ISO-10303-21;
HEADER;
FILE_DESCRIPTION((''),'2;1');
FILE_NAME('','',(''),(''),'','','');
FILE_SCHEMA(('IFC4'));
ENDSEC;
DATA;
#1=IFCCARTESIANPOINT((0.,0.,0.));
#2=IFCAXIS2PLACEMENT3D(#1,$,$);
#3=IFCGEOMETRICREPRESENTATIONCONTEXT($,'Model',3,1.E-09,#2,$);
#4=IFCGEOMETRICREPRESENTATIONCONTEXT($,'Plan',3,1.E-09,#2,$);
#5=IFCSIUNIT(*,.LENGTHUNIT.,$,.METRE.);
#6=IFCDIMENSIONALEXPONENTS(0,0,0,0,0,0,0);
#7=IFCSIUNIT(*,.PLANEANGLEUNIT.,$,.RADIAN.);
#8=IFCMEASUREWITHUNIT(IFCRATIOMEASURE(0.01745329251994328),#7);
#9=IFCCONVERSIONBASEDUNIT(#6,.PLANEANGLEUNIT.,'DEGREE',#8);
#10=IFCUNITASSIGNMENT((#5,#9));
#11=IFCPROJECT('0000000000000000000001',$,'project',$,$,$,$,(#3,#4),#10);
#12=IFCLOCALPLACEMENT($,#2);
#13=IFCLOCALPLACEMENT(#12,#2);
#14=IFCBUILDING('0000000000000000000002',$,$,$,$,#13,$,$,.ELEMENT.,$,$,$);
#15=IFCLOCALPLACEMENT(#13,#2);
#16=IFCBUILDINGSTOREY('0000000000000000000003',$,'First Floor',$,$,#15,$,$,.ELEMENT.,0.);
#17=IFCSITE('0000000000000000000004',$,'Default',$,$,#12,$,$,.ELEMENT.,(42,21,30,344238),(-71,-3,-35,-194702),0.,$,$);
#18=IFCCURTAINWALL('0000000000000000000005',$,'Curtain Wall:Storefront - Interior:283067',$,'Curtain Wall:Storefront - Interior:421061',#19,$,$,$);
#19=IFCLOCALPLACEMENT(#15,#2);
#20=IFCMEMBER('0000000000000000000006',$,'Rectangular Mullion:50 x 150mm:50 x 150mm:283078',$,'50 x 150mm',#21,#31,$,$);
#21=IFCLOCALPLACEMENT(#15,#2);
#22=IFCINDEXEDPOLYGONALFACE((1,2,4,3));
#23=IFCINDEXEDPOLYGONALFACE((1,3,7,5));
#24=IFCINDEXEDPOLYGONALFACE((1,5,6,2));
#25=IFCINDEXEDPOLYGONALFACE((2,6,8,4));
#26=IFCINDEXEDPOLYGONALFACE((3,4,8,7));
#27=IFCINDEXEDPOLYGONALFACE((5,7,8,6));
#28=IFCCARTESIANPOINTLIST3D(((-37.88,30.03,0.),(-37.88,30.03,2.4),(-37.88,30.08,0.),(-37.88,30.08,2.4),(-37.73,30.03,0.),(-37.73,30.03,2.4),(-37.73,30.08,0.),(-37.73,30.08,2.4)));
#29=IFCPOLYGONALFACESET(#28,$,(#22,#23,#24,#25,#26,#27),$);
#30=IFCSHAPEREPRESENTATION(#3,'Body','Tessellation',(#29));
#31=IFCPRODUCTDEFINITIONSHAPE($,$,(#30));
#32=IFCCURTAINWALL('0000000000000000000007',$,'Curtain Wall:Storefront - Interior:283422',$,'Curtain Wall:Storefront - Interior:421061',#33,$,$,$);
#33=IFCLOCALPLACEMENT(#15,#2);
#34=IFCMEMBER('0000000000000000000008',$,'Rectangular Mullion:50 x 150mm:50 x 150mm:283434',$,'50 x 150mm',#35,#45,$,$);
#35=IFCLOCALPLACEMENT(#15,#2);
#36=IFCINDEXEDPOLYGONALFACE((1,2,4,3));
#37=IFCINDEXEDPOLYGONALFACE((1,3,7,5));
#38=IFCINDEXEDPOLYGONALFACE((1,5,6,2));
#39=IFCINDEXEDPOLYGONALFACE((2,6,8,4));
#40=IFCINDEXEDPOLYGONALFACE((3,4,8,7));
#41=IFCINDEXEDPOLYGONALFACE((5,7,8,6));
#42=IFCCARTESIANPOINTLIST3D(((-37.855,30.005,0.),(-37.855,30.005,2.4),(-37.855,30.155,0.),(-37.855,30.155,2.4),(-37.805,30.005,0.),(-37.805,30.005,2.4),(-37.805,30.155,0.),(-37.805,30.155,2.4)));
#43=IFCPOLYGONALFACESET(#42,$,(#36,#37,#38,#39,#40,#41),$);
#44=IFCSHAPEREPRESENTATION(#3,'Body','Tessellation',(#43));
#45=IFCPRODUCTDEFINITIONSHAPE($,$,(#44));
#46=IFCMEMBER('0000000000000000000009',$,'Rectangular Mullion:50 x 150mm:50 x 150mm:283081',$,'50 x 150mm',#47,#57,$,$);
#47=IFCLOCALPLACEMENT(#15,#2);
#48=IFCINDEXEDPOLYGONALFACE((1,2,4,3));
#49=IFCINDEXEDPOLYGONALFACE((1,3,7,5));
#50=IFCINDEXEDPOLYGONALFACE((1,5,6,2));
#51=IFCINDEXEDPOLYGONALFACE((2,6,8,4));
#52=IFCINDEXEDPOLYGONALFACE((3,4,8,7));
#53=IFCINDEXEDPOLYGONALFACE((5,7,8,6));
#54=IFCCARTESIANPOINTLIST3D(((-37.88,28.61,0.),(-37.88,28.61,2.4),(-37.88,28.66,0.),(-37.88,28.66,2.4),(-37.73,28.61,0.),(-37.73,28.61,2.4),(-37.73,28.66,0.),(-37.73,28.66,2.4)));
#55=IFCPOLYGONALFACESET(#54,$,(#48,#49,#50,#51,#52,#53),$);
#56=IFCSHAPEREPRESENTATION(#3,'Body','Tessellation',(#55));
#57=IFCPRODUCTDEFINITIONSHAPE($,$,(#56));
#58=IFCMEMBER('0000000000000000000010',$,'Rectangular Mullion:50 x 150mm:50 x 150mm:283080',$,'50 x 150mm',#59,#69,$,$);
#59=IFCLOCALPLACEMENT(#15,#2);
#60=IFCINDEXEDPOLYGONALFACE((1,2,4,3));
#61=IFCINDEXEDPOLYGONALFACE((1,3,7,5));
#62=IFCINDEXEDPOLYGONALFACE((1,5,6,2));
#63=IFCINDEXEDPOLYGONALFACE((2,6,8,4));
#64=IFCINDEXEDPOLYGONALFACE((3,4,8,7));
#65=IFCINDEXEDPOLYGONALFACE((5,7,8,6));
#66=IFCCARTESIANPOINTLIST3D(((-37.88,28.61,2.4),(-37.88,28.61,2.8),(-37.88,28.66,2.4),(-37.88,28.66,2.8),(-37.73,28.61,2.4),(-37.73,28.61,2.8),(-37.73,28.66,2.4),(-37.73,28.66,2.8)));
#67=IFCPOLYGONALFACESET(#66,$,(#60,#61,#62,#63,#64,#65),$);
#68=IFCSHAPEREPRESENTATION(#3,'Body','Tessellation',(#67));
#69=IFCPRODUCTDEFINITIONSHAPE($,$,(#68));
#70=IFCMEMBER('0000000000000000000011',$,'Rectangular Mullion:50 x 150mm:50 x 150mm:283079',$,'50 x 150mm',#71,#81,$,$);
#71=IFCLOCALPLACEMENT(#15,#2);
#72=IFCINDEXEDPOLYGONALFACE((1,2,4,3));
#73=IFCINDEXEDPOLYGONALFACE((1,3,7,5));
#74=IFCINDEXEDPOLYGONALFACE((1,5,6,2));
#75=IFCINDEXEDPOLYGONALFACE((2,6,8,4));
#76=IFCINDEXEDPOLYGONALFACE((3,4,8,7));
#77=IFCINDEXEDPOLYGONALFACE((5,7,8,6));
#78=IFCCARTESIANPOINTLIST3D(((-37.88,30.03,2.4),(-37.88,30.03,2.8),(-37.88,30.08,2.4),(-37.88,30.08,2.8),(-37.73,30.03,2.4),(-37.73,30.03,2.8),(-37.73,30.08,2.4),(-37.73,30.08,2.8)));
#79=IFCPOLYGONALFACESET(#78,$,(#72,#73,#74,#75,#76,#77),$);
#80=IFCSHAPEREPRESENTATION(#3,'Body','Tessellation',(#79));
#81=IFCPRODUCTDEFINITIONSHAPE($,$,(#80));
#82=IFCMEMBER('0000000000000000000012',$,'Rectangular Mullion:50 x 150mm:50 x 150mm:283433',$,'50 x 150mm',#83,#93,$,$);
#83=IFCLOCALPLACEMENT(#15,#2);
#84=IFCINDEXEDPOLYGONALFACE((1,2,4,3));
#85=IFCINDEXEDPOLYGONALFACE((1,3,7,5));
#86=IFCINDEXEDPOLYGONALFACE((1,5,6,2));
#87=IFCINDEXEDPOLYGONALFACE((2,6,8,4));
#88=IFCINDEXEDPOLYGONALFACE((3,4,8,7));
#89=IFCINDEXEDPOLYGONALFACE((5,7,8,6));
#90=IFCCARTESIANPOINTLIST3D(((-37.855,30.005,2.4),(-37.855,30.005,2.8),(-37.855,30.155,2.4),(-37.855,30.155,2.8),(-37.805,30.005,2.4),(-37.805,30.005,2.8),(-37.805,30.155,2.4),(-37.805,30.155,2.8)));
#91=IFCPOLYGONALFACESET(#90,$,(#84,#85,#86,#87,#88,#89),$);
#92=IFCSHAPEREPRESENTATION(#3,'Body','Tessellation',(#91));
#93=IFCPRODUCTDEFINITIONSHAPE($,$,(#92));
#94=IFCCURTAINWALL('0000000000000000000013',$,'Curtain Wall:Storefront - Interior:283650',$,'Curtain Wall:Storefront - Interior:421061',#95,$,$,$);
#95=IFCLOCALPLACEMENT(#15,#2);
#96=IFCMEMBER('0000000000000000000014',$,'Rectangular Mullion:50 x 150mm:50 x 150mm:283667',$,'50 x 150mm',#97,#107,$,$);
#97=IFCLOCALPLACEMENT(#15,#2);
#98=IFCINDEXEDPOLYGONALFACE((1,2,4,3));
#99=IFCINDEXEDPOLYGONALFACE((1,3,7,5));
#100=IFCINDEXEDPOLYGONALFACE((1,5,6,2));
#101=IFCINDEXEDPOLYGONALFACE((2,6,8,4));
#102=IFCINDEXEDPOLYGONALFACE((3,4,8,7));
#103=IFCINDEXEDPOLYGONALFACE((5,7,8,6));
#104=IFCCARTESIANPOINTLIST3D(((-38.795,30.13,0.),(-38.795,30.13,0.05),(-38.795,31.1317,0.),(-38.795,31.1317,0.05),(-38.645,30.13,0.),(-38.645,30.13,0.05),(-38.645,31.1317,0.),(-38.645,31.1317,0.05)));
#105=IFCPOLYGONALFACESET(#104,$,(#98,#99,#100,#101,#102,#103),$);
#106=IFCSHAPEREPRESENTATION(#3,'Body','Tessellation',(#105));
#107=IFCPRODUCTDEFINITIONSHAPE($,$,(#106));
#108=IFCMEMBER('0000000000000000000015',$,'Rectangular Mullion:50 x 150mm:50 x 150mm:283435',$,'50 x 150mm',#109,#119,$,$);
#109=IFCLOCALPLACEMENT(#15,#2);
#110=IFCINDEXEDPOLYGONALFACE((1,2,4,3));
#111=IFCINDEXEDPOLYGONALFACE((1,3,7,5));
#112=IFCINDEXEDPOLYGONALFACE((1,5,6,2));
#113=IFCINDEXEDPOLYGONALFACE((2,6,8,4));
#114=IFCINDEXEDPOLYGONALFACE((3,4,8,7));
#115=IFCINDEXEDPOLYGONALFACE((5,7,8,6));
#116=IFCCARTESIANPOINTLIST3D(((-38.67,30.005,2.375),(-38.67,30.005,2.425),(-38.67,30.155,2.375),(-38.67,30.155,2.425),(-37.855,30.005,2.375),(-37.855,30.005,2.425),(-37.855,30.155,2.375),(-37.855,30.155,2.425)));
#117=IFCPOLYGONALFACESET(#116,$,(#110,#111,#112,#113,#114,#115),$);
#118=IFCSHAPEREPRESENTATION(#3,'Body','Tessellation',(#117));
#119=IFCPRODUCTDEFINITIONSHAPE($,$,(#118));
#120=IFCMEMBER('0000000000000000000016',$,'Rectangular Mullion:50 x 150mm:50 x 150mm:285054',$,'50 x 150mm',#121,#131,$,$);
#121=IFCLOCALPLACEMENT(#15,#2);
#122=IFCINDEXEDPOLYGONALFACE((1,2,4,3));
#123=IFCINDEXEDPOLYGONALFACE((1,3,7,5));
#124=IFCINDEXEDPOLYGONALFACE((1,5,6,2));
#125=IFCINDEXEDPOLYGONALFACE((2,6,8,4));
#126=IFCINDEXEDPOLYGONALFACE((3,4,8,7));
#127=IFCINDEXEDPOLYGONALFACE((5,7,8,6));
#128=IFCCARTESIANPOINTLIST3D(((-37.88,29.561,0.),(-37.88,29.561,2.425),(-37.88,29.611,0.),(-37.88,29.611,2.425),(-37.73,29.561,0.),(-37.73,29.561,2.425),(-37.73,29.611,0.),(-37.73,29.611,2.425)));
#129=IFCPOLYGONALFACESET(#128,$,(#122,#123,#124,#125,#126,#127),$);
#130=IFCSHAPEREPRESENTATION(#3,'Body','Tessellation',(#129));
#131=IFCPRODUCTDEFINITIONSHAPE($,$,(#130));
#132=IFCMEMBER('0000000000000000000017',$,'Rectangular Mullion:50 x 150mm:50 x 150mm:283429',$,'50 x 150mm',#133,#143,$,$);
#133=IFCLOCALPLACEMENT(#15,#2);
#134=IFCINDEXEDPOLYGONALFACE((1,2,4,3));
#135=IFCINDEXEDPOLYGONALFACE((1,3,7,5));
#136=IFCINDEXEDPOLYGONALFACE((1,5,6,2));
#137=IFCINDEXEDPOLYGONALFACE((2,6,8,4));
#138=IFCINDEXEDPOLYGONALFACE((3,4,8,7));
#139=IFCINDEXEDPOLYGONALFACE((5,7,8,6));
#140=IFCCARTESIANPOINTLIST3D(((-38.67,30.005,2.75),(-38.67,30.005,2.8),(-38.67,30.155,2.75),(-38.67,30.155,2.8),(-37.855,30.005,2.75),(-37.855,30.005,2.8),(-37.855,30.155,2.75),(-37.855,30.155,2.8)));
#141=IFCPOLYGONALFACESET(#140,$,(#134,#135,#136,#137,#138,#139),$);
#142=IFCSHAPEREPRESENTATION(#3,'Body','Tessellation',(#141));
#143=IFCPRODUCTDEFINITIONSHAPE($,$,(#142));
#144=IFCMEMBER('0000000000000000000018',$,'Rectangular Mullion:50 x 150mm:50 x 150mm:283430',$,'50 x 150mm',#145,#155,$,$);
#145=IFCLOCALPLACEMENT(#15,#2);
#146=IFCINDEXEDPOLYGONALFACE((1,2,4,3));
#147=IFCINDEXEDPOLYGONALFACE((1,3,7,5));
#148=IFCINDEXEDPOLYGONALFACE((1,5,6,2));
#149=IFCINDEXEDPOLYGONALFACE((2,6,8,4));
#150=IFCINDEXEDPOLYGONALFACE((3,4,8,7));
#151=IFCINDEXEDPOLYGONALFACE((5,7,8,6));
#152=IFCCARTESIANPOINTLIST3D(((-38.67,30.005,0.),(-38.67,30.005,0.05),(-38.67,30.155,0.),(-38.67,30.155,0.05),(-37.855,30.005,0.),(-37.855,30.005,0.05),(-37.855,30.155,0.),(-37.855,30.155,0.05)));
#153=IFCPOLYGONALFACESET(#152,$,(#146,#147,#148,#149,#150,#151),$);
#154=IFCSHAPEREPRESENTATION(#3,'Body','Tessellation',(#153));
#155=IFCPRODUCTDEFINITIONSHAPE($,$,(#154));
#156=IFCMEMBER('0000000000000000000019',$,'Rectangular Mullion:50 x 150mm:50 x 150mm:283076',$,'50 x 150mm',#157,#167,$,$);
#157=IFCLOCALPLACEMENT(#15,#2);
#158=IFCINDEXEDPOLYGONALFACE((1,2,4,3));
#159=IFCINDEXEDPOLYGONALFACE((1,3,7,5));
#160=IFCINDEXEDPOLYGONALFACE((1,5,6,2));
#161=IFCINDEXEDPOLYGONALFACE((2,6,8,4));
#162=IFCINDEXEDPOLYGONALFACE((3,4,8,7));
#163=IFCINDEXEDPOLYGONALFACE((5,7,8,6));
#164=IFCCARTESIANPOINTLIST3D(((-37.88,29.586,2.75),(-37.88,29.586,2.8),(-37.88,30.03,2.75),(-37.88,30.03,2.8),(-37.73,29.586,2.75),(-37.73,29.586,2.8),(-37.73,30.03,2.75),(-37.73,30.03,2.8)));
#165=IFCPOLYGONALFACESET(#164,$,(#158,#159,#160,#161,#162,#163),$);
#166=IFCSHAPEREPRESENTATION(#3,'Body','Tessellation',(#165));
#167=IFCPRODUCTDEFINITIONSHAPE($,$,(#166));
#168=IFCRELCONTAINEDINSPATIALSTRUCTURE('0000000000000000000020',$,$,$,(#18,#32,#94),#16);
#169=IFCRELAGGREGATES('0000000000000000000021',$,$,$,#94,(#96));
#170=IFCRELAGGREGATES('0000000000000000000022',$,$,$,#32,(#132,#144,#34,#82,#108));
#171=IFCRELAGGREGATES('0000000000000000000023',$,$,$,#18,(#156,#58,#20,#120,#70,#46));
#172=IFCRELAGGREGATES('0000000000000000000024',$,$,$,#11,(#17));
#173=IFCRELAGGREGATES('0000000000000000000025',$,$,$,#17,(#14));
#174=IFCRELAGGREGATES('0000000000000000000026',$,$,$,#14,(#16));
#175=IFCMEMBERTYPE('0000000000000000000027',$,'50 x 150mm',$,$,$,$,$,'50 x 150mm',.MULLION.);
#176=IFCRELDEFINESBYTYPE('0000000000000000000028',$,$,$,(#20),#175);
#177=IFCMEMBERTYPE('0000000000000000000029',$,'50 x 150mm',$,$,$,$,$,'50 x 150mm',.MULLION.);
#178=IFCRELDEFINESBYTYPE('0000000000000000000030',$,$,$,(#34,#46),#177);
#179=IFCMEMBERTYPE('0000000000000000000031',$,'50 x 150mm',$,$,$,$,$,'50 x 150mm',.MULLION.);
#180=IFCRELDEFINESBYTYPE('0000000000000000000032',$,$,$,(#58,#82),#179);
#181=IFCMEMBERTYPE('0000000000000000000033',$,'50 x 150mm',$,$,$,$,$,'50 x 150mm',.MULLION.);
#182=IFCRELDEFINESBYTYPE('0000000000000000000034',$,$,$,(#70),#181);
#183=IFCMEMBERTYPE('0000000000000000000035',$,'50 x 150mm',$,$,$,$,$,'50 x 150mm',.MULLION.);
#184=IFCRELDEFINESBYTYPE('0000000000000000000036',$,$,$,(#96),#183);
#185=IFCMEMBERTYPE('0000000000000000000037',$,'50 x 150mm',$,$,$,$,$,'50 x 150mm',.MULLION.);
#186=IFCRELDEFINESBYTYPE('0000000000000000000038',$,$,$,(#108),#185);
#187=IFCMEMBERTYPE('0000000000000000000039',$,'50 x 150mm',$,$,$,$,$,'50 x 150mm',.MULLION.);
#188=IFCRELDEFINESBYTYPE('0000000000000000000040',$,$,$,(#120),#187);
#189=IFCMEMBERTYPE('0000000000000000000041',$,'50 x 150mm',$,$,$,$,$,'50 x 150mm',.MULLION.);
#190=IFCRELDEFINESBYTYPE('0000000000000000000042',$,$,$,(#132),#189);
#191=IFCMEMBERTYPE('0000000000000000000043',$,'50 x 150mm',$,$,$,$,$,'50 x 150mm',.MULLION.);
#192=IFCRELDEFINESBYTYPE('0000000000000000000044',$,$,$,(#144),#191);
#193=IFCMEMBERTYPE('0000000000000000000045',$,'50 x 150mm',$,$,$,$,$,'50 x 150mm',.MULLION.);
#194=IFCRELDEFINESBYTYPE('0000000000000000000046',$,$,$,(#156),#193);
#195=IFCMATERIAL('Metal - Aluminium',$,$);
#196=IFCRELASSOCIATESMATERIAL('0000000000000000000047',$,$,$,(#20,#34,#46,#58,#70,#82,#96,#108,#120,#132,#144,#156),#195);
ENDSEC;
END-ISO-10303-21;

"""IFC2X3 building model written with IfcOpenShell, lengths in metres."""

from ifc_helpers import new_model, entity, si_unit, converted_unit, frame, origin, origin_2d_with_axis, place, context, project, spatial, rectangle, extrude, source, transform, mapped, material, type_object, type_shapes, element, aggregate, save


model = new_model("IFC2X3")

# Units and contexts
model_context = context("Model", 3, precision=1e-09, world=origin())
plan_context = context("Plan", 3, precision=1e-09, world=origin())
ifc_project = project(units=[si_unit("LENGTHUNIT", "METRE"), converted_unit("PLANEANGLEUNIT", "DEGREE", entity("IfcRatioMeasure", 0.01745329251994328), si_unit("PLANEANGLEUNIT", "RADIAN"), dimensions=[0, 0, 0, 0, 0, 0, 0])], contexts=[model_context, plan_context])

# Site, building, storey
site_placement = place(None, origin())
site = spatial("IfcSite", under=ifc_project, at=site_placement, Name="Default", CompositionType="ELEMENT", RefLatitude=(42, 21, 30, 344238), RefLongitude=(-71, -3, -35, -194702), RefElevation=0.0)
building_placement = place(site_placement, origin())
building = spatial("IfcBuilding", under=site, at=building_placement, CompositionType="ELEMENT")
storey_placement = place(building_placement, origin())
storey = spatial("IfcBuildingStorey", under=building, at=storey_placement, Name="First Floor", CompositionType="ELEMENT", Elevation=0.0)

# Curtain walls, members
curtain_wall_1_placement = place(storey_placement, origin())
curtain_wall_1 = element("IfcCurtainWall", 1, at=curtain_wall_1_placement, inside=storey, Name="Curtain Wall:Storefront - Interior:283067", ObjectType="Curtain Wall:Storefront - Interior:421061")
ifc_material_1 = material(Name="Metal - Aluminium")
member_type_1 = type_object("IfcMemberType", Name="50 x 150mm", ElementType="50 x 150mm", PredefinedType="MULLION")
shared_shape_1 = source(origin(), model_context, "Body", "SweptSolid", [
    extrude(rectangle(XDim=0.05, YDim=0.15, at=origin_2d_with_axis()), frame((-0.025, 0.0, -2.4), z_axis=(0.0, 0.0, 1.0), x_axis=(-1.0, 0.0, 0.0)), (0.0, 0.0, 1.0), 2.4),
])
type_shapes(member_type_1, [shared_shape_1])
member_1_placement = place(storey_placement, frame((-37.805, 30.08, 0.0), z_axis=(0.0, 0.0, -1.0), x_axis=(0.0, 1.0, 0.0)))
member_1 = element("IfcMember", 2, at=member_1_placement, type_object=member_type_1, material=ifc_material_1, Name="Rectangular Mullion:50 x 150mm:50 x 150mm:283078", ObjectType="50 x 150mm", context=model_context, shape_type="MappedRepresentation", body=[
    mapped(shared_shape_1, transform((0.0, 0.0, 0.0), scale=1.0)),
])
curtain_wall_2_placement = place(storey_placement, origin())
curtain_wall_2 = element("IfcCurtainWall", 3, at=curtain_wall_2_placement, inside=storey, Name="Curtain Wall:Storefront - Interior:283422", ObjectType="Curtain Wall:Storefront - Interior:421061")
member_type_2 = type_object("IfcMemberType", Name="50 x 150mm", ElementType="50 x 150mm", PredefinedType="MULLION")
type_shapes(member_type_2, [shared_shape_1])
member_2_placement = place(storey_placement, frame((-37.805, 30.08, 2.4)))
member_2 = element("IfcMember", 4, at=member_2_placement, type_object=member_type_2, material=ifc_material_1, Name="Rectangular Mullion:50 x 150mm:50 x 150mm:283434", ObjectType="50 x 150mm", context=model_context, shape_type="MappedRepresentation", body=[
    mapped(shared_shape_1, transform((0.0, 0.0, 0.0), scale=1.0)),
])

# Members
member_3_placement = place(storey_placement, frame((-37.805, 28.61, 2.4), z_axis=(0.0, 0.0, 1.0), x_axis=(0.0, -1.0, 0.0)))
member_3 = element("IfcMember", 5, at=member_3_placement, type_object=member_type_2, material=ifc_material_1, Name="Rectangular Mullion:50 x 150mm:50 x 150mm:283081", ObjectType="50 x 150mm", context=model_context, shape_type="MappedRepresentation", body=[
    mapped(shared_shape_1, transform((0.0, 0.0, 0.0), scale=1.0)),
])
member_type_3 = type_object("IfcMemberType", Name="50 x 150mm", ElementType="50 x 150mm", PredefinedType="MULLION")
shared_shape_2 = source(origin(), model_context, "Body", "SweptSolid", [
    extrude(rectangle(XDim=0.05, YDim=0.15, at=origin_2d_with_axis()), frame((-0.025, 0.0, -0.4), z_axis=(0.0, 0.0, 1.0), x_axis=(-1.0, 0.0, 0.0)), (0.0, 0.0, 1.0), 0.4),
])
type_shapes(member_type_3, [shared_shape_2])
member_4_placement = place(storey_placement, frame((-37.805, 28.61, 2.8), z_axis=(0.0, 0.0, 1.0), x_axis=(0.0, -1.0, 0.0)))
member_4 = element("IfcMember", 6, at=member_4_placement, type_object=member_type_3, material=ifc_material_1, Name="Rectangular Mullion:50 x 150mm:50 x 150mm:283080", ObjectType="50 x 150mm", context=model_context, shape_type="MappedRepresentation", body=[
    mapped(shared_shape_2, transform((0.0, 0.0, 0.0), scale=1.0)),
])
member_type_4 = type_object("IfcMemberType", Name="50 x 150mm", ElementType="50 x 150mm", PredefinedType="MULLION")
type_shapes(member_type_4, [shared_shape_2])
member_5_placement = place(storey_placement, frame((-37.805, 30.08, 2.4), z_axis=(0.0, 0.0, -1.0), x_axis=(0.0, 1.0, 0.0)))
member_5 = element("IfcMember", 7, at=member_5_placement, type_object=member_type_4, material=ifc_material_1, Name="Rectangular Mullion:50 x 150mm:50 x 150mm:283079", ObjectType="50 x 150mm", context=model_context, shape_type="MappedRepresentation", body=[
    mapped(shared_shape_2, transform((0.0, 0.0, 0.0), scale=1.0)),
])
member_6_placement = place(storey_placement, frame((-37.805, 30.08, 2.8)))
member_6 = element("IfcMember", 8, at=member_6_placement, type_object=member_type_3, material=ifc_material_1, Name="Rectangular Mullion:50 x 150mm:50 x 150mm:283433", ObjectType="50 x 150mm", context=model_context, shape_type="MappedRepresentation", body=[
    mapped(shared_shape_2, transform((0.0, 0.0, 0.0), scale=1.0)),
])

# Curtain wall, member
curtain_wall_3_placement = place(storey_placement, origin())
curtain_wall_3 = element("IfcCurtainWall", 9, at=curtain_wall_3_placement, inside=storey, Name="Curtain Wall:Storefront - Interior:283650", ObjectType="Curtain Wall:Storefront - Interior:421061")
member_type_5 = type_object("IfcMemberType", Name="50 x 150mm", ElementType="50 x 150mm", PredefinedType="MULLION")
shared_shape_3 = source(origin(), model_context, "Body", "SweptSolid", [
    extrude(rectangle(XDim=0.05, YDim=0.15, at=origin_2d_with_axis()), frame((-0.025, 0.0, -1.0017), z_axis=(0.0, 0.0, 1.0), x_axis=(-1.0, 0.0, 0.0)), (0.0, 0.0, 1.0), 1.0017),
])
type_shapes(member_type_5, [shared_shape_3])
member_7_placement = place(storey_placement, frame((-38.72, 30.13, 0.0), z_axis=(0.0, -1.0, 0.0), x_axis=(0.0, 0.0, -1.0)))
member_7 = element("IfcMember", 10, at=member_7_placement, type_object=member_type_5, material=ifc_material_1, Name="Rectangular Mullion:50 x 150mm:50 x 150mm:283667", ObjectType="50 x 150mm", context=model_context, shape_type="MappedRepresentation", body=[
    mapped(shared_shape_3, transform((0.0, 0.0, 0.0), scale=1.0)),
])

# Members
member_type_6 = type_object("IfcMemberType", Name="50 x 150mm", ElementType="50 x 150mm", PredefinedType="MULLION")
shared_shape_4 = source(origin(), model_context, "Body", "SweptSolid", [
    extrude(rectangle(XDim=0.05, YDim=0.15, at=origin_2d_with_axis()), frame((0.0, 0.0, -0.815), z_axis=(0.0, 0.0, 1.0), x_axis=(-1.0, 0.0, 0.0)), (0.0, 0.0, 1.0), 0.815),
])
type_shapes(member_type_6, [shared_shape_4])
member_8_placement = place(storey_placement, frame((-38.67, 30.08, 2.4), z_axis=(-1.0, 0.0, 0.0), x_axis=(0.0, 0.0, 1.0)))
member_8 = element("IfcMember", 11, at=member_8_placement, type_object=member_type_6, material=ifc_material_1, Name="Rectangular Mullion:50 x 150mm:50 x 150mm:283435", ObjectType="50 x 150mm", context=model_context, shape_type="MappedRepresentation", body=[
    mapped(shared_shape_4, transform((0.0, 0.0, 0.0), scale=1.0)),
])
member_type_7 = type_object("IfcMemberType", Name="50 x 150mm", ElementType="50 x 150mm", PredefinedType="MULLION")
shared_shape_5 = source(origin(), model_context, "Body", "SweptSolid", [
    extrude(rectangle(XDim=0.05, YDim=0.15, at=origin_2d_with_axis()), frame((0.0, 0.0, -2.425), z_axis=(0.0, 0.0, 1.0), x_axis=(-1.0, 0.0, 0.0)), (0.0, 0.0, 1.0), 2.425),
])
type_shapes(member_type_7, [shared_shape_5])
member_9_placement = place(storey_placement, frame((-37.805, 29.586, 0.0), z_axis=(0.0, 0.0, -1.0), x_axis=(0.0, 1.0, 0.0)))
member_9 = element("IfcMember", 12, at=member_9_placement, type_object=member_type_7, material=ifc_material_1, Name="Rectangular Mullion:50 x 150mm:50 x 150mm:285054", ObjectType="50 x 150mm", context=model_context, shape_type="MappedRepresentation", body=[
    mapped(shared_shape_5, transform((0.0, 0.0, 0.0), scale=1.0)),
])
member_type_8 = type_object("IfcMemberType", Name="50 x 150mm", ElementType="50 x 150mm", PredefinedType="MULLION")
shared_shape_6 = source(origin(), model_context, "Body", "SweptSolid", [
    extrude(rectangle(XDim=0.05, YDim=0.15, at=origin_2d_with_axis()), frame((-0.025, 0.0, -0.815), z_axis=(0.0, 0.0, 1.0), x_axis=(-1.0, 0.0, 0.0)), (0.0, 0.0, 1.0), 0.815),
])
type_shapes(member_type_8, [shared_shape_6])
member_10_placement = place(storey_placement, frame((-38.67, 30.08, 2.8), z_axis=(-1.0, 0.0, 0.0), x_axis=(0.0, 0.0, 1.0)))
member_10 = element("IfcMember", 13, at=member_10_placement, type_object=member_type_8, material=ifc_material_1, Name="Rectangular Mullion:50 x 150mm:50 x 150mm:283429", ObjectType="50 x 150mm", context=model_context, shape_type="MappedRepresentation", body=[
    mapped(shared_shape_6, transform((0.0, 0.0, 0.0), scale=1.0)),
])
member_type_9 = type_object("IfcMemberType", Name="50 x 150mm", ElementType="50 x 150mm", PredefinedType="MULLION")
shared_shape_7 = source(origin(), model_context, "Body", "SweptSolid", [
    extrude(rectangle(XDim=0.05, YDim=0.15, at=origin_2d_with_axis()), frame((-0.025, 0.0, -0.815), z_axis=(0.0, 0.0, 1.0), x_axis=(-1.0, 0.0, 0.0)), (0.0, 0.0, 1.0), 0.815),
])
type_shapes(member_type_9, [shared_shape_7])
member_11_placement = place(storey_placement, frame((-37.855, 30.08, 0.0), z_axis=(1.0, 0.0, 0.0), x_axis=(0.0, 0.0, -1.0)))
member_11 = element("IfcMember", 14, at=member_11_placement, type_object=member_type_9, material=ifc_material_1, Name="Rectangular Mullion:50 x 150mm:50 x 150mm:283430", ObjectType="50 x 150mm", context=model_context, shape_type="MappedRepresentation", body=[
    mapped(shared_shape_7, transform((0.0, 0.0, 0.0), scale=1.0)),
])
member_type_10 = type_object("IfcMemberType", Name="50 x 150mm", ElementType="50 x 150mm", PredefinedType="MULLION")
shared_shape_8 = source(origin(), model_context, "Body", "SweptSolid", [
    extrude(rectangle(XDim=0.05, YDim=0.15, at=origin_2d_with_axis()), frame((-0.025, 0.0, -0.444), z_axis=(0.0, 0.0, 1.0), x_axis=(-1.0, 0.0, 0.0)), (0.0, 0.0, 1.0), 0.444),
])
type_shapes(member_type_10, [shared_shape_8])
member_12_placement = place(storey_placement, frame((-37.805, 30.03, 2.8), z_axis=(0.0, 1.0, 0.0), x_axis=(0.0, 0.0, 1.0)))
member_12 = element("IfcMember", 15, at=member_12_placement, type_object=member_type_10, material=ifc_material_1, Name="Rectangular Mullion:50 x 150mm:50 x 150mm:283076", ObjectType="50 x 150mm", context=model_context, shape_type="MappedRepresentation", body=[
    mapped(shared_shape_8, transform((0.0, 0.0, 0.0), scale=1.0)),
])

aggregate(curtain_wall_3, [member_7])
aggregate(curtain_wall_2, [member_10, member_11, member_2, member_6, member_8])

aggregate(curtain_wall_1, [member_12, member_4, member_1, member_9, member_5, member_3])

save(model, "model.ifc")
